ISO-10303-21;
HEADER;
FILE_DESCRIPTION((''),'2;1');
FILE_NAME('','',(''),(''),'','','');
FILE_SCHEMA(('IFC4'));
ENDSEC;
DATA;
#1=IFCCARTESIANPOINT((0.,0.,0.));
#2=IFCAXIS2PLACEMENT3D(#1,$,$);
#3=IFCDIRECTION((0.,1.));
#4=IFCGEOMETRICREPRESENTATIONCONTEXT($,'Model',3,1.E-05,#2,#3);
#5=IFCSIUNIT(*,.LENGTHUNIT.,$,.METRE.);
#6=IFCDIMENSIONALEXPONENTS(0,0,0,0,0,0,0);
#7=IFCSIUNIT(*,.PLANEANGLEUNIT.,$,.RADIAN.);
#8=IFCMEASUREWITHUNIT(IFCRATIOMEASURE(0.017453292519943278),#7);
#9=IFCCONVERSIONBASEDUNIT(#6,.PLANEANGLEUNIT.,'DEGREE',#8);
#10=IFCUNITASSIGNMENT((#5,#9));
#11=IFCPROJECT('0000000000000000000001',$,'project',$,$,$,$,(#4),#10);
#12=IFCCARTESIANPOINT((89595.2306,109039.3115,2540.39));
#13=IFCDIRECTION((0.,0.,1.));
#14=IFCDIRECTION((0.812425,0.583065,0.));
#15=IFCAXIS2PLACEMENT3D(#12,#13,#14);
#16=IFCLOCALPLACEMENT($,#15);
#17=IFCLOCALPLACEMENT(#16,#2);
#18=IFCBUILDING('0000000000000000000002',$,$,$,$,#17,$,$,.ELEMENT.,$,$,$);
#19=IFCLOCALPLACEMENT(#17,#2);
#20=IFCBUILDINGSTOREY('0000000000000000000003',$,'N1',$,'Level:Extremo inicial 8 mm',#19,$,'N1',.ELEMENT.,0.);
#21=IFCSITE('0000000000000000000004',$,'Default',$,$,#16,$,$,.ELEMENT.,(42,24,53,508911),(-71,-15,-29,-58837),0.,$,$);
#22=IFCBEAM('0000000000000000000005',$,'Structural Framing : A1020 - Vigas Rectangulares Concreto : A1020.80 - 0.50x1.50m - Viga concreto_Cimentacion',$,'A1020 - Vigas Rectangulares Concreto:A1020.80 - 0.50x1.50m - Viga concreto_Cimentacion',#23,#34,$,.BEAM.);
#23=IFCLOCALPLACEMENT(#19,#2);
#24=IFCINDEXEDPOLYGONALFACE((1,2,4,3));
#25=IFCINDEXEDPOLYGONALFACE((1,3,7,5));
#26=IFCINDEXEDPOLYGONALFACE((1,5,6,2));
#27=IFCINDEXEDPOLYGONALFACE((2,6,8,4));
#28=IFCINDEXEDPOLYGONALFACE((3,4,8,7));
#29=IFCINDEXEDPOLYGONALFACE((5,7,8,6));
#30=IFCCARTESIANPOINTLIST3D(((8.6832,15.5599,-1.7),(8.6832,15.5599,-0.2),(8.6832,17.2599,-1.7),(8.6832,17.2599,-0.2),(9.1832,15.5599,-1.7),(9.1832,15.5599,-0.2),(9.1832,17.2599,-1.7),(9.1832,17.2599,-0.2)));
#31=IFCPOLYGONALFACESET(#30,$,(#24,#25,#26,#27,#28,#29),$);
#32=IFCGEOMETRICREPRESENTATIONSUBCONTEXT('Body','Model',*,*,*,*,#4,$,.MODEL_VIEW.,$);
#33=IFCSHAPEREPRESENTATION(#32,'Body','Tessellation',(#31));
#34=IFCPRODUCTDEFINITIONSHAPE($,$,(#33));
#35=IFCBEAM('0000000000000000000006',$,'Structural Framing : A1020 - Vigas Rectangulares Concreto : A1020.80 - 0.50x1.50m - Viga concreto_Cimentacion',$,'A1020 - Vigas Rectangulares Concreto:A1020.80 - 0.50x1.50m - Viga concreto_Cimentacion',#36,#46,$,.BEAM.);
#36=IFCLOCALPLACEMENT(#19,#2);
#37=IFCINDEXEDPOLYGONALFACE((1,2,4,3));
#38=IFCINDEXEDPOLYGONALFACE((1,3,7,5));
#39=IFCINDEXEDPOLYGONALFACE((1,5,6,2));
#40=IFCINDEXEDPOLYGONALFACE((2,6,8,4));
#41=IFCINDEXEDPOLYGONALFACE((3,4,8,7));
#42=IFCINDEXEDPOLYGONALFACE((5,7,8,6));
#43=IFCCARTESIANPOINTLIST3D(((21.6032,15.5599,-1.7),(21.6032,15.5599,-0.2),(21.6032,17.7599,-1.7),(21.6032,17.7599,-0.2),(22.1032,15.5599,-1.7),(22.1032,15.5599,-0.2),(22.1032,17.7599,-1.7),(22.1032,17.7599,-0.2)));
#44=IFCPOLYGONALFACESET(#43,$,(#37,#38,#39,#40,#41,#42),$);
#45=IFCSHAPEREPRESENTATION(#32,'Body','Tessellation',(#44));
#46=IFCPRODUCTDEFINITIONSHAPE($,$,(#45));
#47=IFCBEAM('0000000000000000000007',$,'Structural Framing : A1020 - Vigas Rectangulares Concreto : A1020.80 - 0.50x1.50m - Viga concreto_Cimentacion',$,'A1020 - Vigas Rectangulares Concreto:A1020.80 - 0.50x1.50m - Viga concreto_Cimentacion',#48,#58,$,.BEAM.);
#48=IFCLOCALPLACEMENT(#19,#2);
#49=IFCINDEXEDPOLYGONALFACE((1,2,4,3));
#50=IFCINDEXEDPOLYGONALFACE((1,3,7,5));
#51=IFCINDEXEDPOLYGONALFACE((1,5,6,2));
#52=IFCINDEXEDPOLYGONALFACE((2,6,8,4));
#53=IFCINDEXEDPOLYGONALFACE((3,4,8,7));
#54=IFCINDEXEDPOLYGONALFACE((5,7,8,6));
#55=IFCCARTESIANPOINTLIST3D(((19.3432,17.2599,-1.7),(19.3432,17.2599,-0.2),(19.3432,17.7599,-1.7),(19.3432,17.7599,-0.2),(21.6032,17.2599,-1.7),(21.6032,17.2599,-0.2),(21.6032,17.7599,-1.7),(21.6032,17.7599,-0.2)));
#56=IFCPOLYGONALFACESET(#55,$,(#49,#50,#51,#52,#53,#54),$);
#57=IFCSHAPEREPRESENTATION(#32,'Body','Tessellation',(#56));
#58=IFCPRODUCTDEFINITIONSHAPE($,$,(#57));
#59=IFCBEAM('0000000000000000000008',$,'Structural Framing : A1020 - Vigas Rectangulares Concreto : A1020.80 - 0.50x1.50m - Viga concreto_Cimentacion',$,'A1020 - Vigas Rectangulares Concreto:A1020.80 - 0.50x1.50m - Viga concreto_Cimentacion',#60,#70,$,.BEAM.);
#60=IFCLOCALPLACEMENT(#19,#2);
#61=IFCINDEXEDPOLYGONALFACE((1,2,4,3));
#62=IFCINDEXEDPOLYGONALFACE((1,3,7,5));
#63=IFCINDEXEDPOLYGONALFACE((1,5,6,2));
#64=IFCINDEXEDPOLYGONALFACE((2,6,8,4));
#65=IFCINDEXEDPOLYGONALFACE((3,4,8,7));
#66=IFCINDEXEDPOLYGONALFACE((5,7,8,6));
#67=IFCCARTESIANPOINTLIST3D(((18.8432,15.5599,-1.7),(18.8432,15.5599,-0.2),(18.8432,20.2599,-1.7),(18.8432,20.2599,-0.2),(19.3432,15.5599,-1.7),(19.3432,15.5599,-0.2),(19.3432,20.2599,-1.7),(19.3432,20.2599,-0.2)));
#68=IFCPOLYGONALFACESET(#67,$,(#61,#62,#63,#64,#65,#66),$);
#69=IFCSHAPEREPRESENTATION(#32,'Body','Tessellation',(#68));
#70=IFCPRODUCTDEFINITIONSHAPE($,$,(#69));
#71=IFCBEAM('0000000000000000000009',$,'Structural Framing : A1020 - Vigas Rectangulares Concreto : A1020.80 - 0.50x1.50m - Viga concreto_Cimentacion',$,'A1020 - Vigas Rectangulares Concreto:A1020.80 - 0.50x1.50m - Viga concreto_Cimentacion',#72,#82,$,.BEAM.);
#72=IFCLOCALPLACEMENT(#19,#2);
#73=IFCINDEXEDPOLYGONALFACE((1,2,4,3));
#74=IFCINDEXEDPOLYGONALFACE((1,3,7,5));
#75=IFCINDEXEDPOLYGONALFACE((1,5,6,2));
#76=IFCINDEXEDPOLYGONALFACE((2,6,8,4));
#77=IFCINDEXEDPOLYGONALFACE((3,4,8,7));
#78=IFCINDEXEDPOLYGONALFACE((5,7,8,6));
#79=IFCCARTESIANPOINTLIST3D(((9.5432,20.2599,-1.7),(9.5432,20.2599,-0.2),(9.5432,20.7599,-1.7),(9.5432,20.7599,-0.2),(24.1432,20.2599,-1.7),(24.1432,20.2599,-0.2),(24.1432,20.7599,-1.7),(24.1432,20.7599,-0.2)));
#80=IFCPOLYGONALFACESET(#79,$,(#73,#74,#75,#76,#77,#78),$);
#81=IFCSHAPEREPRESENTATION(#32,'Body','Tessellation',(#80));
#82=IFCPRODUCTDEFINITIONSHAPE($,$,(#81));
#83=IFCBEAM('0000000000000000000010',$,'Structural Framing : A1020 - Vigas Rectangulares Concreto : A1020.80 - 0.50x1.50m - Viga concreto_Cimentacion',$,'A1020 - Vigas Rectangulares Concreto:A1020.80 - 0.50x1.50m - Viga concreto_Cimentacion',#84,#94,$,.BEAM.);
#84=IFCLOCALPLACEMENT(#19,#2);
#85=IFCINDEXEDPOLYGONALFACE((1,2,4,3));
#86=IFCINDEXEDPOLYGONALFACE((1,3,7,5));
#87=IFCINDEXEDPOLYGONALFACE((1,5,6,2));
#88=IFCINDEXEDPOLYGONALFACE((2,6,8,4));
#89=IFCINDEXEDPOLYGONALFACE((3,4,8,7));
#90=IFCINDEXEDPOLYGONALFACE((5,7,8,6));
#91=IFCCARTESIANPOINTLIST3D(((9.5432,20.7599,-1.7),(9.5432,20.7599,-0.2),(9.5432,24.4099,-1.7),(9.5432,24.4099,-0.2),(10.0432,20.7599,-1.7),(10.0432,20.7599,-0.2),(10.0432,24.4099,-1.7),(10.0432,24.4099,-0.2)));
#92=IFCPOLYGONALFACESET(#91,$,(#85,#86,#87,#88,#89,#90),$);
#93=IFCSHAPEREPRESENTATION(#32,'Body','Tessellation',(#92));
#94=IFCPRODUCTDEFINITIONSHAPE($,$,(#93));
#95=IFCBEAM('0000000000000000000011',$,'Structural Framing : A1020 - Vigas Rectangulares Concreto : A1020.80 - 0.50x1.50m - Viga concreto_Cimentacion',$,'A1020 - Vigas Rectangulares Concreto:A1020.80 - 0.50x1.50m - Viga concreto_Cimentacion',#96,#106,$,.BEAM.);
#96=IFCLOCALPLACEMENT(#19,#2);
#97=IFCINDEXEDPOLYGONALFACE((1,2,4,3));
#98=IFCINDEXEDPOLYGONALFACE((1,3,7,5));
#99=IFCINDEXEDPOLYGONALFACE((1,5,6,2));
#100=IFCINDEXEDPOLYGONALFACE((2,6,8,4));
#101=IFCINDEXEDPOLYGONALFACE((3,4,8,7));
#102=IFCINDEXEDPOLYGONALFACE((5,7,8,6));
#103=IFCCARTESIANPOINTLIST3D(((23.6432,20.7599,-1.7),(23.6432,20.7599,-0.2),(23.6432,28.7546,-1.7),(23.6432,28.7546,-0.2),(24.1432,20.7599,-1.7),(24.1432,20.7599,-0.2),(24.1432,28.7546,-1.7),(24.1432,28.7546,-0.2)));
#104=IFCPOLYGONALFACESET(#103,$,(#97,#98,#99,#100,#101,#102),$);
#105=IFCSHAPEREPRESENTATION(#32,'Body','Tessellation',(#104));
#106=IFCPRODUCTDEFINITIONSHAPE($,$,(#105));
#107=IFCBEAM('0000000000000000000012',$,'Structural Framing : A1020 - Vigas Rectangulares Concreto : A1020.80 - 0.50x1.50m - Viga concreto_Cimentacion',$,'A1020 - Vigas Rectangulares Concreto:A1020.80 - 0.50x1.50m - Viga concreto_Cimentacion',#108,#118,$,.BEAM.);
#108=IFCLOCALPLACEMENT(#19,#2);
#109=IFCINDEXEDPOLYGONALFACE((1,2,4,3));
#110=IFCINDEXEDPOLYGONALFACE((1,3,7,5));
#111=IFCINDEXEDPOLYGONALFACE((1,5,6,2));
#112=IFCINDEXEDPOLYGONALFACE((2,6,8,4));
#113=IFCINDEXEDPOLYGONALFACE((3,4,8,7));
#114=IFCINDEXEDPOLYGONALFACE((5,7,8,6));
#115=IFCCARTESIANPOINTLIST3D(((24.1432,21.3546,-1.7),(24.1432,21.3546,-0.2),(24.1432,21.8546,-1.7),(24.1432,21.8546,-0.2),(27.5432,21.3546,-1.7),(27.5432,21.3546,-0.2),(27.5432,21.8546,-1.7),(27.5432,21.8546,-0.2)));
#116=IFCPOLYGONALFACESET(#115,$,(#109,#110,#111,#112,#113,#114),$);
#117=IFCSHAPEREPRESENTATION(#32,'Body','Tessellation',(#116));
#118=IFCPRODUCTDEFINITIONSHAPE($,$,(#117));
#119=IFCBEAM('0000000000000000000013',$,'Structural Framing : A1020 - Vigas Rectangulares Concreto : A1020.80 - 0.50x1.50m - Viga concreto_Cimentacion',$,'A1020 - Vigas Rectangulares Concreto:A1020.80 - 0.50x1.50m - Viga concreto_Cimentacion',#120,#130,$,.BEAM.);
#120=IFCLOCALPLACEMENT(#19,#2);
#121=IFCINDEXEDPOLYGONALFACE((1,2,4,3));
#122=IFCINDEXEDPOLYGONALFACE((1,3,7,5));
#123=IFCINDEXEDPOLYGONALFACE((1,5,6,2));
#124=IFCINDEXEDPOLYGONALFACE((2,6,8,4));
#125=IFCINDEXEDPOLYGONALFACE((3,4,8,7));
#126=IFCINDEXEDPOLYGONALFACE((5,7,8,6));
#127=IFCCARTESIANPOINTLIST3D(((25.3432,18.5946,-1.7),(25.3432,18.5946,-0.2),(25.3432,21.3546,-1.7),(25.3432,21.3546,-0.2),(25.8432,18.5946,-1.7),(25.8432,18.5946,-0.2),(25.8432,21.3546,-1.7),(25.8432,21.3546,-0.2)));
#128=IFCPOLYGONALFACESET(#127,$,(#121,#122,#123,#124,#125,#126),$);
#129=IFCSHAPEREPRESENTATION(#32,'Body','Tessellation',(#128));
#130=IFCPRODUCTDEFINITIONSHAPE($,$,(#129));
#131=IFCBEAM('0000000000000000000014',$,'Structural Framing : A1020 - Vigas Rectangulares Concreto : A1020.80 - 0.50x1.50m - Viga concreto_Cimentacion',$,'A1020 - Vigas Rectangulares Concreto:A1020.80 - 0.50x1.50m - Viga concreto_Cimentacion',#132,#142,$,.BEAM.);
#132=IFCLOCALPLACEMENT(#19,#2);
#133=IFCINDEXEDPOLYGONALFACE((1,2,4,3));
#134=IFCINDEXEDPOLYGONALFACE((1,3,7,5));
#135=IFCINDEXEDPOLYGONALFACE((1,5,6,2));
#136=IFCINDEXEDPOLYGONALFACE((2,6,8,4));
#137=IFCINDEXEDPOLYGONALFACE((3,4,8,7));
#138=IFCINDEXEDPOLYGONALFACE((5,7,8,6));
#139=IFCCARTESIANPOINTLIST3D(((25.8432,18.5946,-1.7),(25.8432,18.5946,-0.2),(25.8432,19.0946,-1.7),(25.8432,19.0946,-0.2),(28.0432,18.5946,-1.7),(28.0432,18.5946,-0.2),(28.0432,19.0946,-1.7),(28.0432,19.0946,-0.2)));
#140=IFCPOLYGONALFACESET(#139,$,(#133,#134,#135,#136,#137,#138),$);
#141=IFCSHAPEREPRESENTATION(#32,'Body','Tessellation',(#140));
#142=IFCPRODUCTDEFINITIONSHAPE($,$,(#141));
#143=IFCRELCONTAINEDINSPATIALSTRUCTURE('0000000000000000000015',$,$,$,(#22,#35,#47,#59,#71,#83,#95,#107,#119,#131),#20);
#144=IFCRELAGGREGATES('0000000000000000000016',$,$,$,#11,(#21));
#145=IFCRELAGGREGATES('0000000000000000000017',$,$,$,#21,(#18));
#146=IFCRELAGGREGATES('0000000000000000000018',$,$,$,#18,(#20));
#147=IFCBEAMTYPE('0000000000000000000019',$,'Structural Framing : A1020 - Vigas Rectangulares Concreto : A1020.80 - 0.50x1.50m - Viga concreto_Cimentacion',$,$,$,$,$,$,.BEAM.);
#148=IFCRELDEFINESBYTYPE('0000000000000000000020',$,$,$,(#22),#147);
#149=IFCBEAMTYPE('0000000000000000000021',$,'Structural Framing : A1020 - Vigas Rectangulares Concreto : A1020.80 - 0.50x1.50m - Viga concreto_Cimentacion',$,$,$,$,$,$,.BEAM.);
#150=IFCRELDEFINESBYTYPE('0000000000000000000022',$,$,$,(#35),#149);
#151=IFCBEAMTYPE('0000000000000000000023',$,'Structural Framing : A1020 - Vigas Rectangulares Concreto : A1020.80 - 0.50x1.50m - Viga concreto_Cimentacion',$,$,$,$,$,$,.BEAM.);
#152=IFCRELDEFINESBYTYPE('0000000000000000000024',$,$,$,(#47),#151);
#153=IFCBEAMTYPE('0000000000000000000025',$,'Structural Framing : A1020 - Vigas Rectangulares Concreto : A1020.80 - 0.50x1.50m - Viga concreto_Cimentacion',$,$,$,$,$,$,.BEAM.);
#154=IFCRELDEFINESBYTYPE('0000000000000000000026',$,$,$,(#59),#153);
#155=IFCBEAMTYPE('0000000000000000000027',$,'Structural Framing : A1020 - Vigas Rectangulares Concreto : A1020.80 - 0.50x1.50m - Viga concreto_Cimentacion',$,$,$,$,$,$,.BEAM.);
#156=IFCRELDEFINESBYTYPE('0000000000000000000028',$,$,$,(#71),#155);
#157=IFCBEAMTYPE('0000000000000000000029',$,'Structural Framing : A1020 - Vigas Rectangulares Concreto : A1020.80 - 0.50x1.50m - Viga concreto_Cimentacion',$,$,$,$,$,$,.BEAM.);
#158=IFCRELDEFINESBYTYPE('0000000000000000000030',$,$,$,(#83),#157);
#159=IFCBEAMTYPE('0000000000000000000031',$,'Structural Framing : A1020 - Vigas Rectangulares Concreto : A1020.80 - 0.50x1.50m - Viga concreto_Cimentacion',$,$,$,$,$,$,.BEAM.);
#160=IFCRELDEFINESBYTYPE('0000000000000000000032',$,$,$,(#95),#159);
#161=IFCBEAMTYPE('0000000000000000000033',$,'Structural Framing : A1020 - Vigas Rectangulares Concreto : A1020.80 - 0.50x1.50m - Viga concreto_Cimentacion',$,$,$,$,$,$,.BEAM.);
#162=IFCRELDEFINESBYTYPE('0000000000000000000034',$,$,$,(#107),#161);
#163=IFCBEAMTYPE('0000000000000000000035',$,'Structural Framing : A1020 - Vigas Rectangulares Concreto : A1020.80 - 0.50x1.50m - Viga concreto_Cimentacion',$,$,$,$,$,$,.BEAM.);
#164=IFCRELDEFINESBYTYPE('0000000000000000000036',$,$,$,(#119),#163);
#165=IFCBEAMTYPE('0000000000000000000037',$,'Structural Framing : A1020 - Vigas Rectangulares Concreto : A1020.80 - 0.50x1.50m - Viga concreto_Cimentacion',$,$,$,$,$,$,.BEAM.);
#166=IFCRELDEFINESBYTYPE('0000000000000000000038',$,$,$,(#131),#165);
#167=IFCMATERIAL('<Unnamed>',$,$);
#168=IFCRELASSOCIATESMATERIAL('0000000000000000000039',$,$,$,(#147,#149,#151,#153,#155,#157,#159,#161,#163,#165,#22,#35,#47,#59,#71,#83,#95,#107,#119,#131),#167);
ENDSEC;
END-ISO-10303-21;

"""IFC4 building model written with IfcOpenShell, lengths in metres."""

from ifc_helpers import new_model, entity, si_unit, converted_unit, direction, frame, frame_2d, origin, place, context, subcontext, project, spatial, polyline, segment, composite_curve, rectangle, outline, extrude, source, transform, mapped, material, material_profile, profile_set, profile_usage, type_object, type_shapes, element, save


model = new_model("IFC4")

# Units and contexts
model_context = context("Model", 3, precision=1e-05, world=origin(), true_north=direction((0.0, 1.0)))
body_context = subcontext(model_context, "Body", "Model", "MODEL_VIEW")
ifc_project = project(units=[si_unit("LENGTHUNIT", "METRE"), converted_unit("PLANEANGLEUNIT", "DEGREE", entity("IfcRatioMeasure", 0.017453292519943278), si_unit("PLANEANGLEUNIT", "RADIAN"), dimensions=[0, 0, 0, 0, 0, 0, 0])], contexts=[model_context])

# Site, building, storey
site_placement = place(None, frame((89595.2306, 109039.3115, 2540.39), z_axis=(0.0, 0.0, 1.0), x_axis=(0.812425, 0.583065, 0.0)))
site = spatial("IfcSite", under=ifc_project, at=site_placement, Name="Default", CompositionType="ELEMENT", RefLatitude=(42, 24, 53, 508911), RefLongitude=(-71, -15, -29, -58837), RefElevation=0.0)
building_placement = place(site_placement, origin())
building = spatial("IfcBuilding", under=site, at=building_placement, CompositionType="ELEMENT")
storey_placement = place(building_placement, origin())
storey = spatial("IfcBuildingStorey", under=building, at=storey_placement, Name="N1", ObjectType="Level:Extremo inicial 8 mm", LongName="N1", CompositionType="ELEMENT", Elevation=0.0)

# Beams
ifc_material_1 = material(Name="<Unnamed>")
ifc_material_profile_1 = material_profile(ifc_material_1, outline(composite_curve([segment(polyline([(0.25, 0.75, 0.0), (0.25, -0.75, 0.0)]), True, "CONTINUOUS"), segment(polyline([(0.25, -0.75, 0.0), (-0.25, -0.75, 0.0)]), True, "CONTINUOUS"), segment(polyline([(-0.25, -0.75, 0.0), (-0.25, 0.75, 0.0)]), True, "CONTINUOUS"), segment(polyline([(-0.25, 0.75, 0.0), (0.25, 0.75, 0.0)]), True, "CONTINUOUS")], self_intersect=False), kind="CURVE"), Name="A1020.80 - 0.50x1.50m - Viga concreto_Cimentacion")
ifc_material_profile_2 = material_profile(ifc_material_1, outline(composite_curve([segment(polyline([(-5.3373, 0.25, 0.75), (-5.3373, 0.25, -0.75)]), True, "CONTINUOUS"), segment(polyline([(-5.3373, 0.25, -0.75), (-5.3373, -0.25, -0.75)]), True, "CONTINUOUS"), segment(polyline([(-5.3373, -0.25, -0.75), (-5.3373, -0.25, 0.75)]), True, "CONTINUOUS"), segment(polyline([(-5.3373, -0.25, 0.75), (-5.3373, 0.25, 0.75)]), True, "CONTINUOUS")], self_intersect=False), kind="CURVE"), Name="A1020.80 - 0.50x1.50m - Viga concreto_Cimentacion")
ifc_profile_set_1 = profile_set([ifc_material_profile_1, ifc_material_profile_2], Name="A1020.80 - 0.50x1.50m - Viga concreto_Cimentacion")
ifc_profile_usage_1 = profile_usage(ifc_profile_set_1, cardinal=8)
beam_type_1 = type_object("IfcBeamType", Name="Structural Framing : A1020 - Vigas Rectangulares Concreto : A1020.80 - 0.50x1.50m - Viga concreto_Cimentacion", PredefinedType="BEAM", material=ifc_profile_set_1)
shared_shape_1 = source(origin(), body_context, "Body", "SweptSolid", [
    extrude(rectangle(XDim=1.5, YDim=0.5, at=frame_2d((0.0, 0.0), x_axis=(0.0, 1.0))), frame((8.9332, 17.2599, -0.95), z_axis=(0.0, -1.0, 0.0), x_axis=(-1.0, 0.0, 0.0)), (0.0, 0.0, 1.0), 1.7),
])
type_shapes(beam_type_1, [shared_shape_1])
beam_1_placement = place(storey_placement, origin())
element("IfcBeam", 1, at=beam_1_placement, inside=storey, type_object=beam_type_1, material=ifc_profile_usage_1, Name="Structural Framing : A1020 - Vigas Rectangulares Concreto : A1020.80 - 0.50x1.50m - Viga concreto_Cimentacion", ObjectType="A1020 - Vigas Rectangulares Concreto:A1020.80 - 0.50x1.50m - Viga concreto_Cimentacion", PredefinedType="BEAM", context=body_context, shape_type="MappedRepresentation", body=[
    mapped(shared_shape_1, transform((0.0, 0.0, 0.0), scale=1.0)),
])
ifc_profile_usage_2 = profile_usage(ifc_profile_set_1, cardinal=8)
beam_type_2 = type_object("IfcBeamType", Name="Structural Framing : A1020 - Vigas Rectangulares Concreto : A1020.80 - 0.50x1.50m - Viga concreto_Cimentacion", PredefinedType="BEAM", material=ifc_profile_set_1)
shared_shape_2 = source(origin(), body_context, "Body", "SweptSolid", [
    extrude(rectangle(XDim=1.5, YDim=0.5, at=frame_2d((0.0, 0.0), x_axis=(0.0, 1.0))), frame((21.8532, 15.5599, -0.95), z_axis=(0.0, 1.0, 0.0), x_axis=(-1.0, 0.0, 0.0)), (0.0, 0.0, 1.0), 2.2),
])
type_shapes(beam_type_2, [shared_shape_2])
beam_2_placement = place(storey_placement, origin())
element("IfcBeam", 2, at=beam_2_placement, inside=storey, type_object=beam_type_2, material=ifc_profile_usage_2, Name="Structural Framing : A1020 - Vigas Rectangulares Concreto : A1020.80 - 0.50x1.50m - Viga concreto_Cimentacion", ObjectType="A1020 - Vigas Rectangulares Concreto:A1020.80 - 0.50x1.50m - Viga concreto_Cimentacion", PredefinedType="BEAM", context=body_context, shape_type="MappedRepresentation", body=[
    mapped(shared_shape_2, transform((0.0, 0.0, 0.0), scale=1.0)),
])
ifc_profile_usage_3 = profile_usage(ifc_profile_set_1, cardinal=8)
beam_type_3 = type_object("IfcBeamType", Name="Structural Framing : A1020 - Vigas Rectangulares Concreto : A1020.80 - 0.50x1.50m - Viga concreto_Cimentacion", PredefinedType="BEAM", material=ifc_profile_set_1)
shared_shape_3 = source(origin(), body_context, "Body", "SweptSolid", [
    extrude(rectangle(XDim=1.5, YDim=0.5, at=frame_2d((0.0, 0.0), x_axis=(1.0, 0.0))), frame((21.6032, 17.5099, -0.95), z_axis=(-1.0, 0.0, 0.0), x_axis=(0.0, 0.0, -1.0)), (0.0, 0.0, 1.0), 2.26),
])
type_shapes(beam_type_3, [shared_shape_3])
beam_3_placement = place(storey_placement, origin())
element("IfcBeam", 3, at=beam_3_placement, inside=storey, type_object=beam_type_3, material=ifc_profile_usage_3, Name="Structural Framing : A1020 - Vigas Rectangulares Concreto : A1020.80 - 0.50x1.50m - Viga concreto_Cimentacion", ObjectType="A1020 - Vigas Rectangulares Concreto:A1020.80 - 0.50x1.50m - Viga concreto_Cimentacion", PredefinedType="BEAM", context=body_context, shape_type="MappedRepresentation", body=[
    mapped(shared_shape_3, transform((0.0, 0.0, 0.0), scale=1.0)),
])
ifc_profile_usage_4 = profile_usage(ifc_profile_set_1, cardinal=8)
beam_type_4 = type_object("IfcBeamType", Name="Structural Framing : A1020 - Vigas Rectangulares Concreto : A1020.80 - 0.50x1.50m - Viga concreto_Cimentacion", PredefinedType="BEAM", material=ifc_profile_set_1)
shared_shape_4 = source(origin(), body_context, "Body", "SweptSolid", [
    extrude(rectangle(XDim=1.5, YDim=0.5, at=frame_2d((0.0, 0.0), x_axis=(0.0, 1.0))), frame((19.0932, 15.5599, -0.95), z_axis=(0.0, 1.0, 0.0), x_axis=(-1.0, 0.0, 0.0)), (0.0, 0.0, 1.0), 4.7),
])
type_shapes(beam_type_4, [shared_shape_4])
beam_4_placement = place(storey_placement, origin())
element("IfcBeam", 4, at=beam_4_placement, inside=storey, type_object=beam_type_4, material=ifc_profile_usage_4, Name="Structural Framing : A1020 - Vigas Rectangulares Concreto : A1020.80 - 0.50x1.50m - Viga concreto_Cimentacion", ObjectType="A1020 - Vigas Rectangulares Concreto:A1020.80 - 0.50x1.50m - Viga concreto_Cimentacion", PredefinedType="BEAM", context=body_context, shape_type="MappedRepresentation", body=[
    mapped(shared_shape_4, transform((0.0, 0.0, 0.0), scale=1.0)),
])
ifc_profile_usage_5 = profile_usage(ifc_profile_set_1, cardinal=8)
beam_type_5 = type_object("IfcBeamType", Name="Structural Framing : A1020 - Vigas Rectangulares Concreto : A1020.80 - 0.50x1.50m - Viga concreto_Cimentacion", PredefinedType="BEAM", material=ifc_profile_set_1)
shared_shape_5 = source(origin(), body_context, "Body", "SweptSolid", [
    extrude(rectangle(XDim=1.5, YDim=0.5, at=frame_2d((0.0, 0.0), x_axis=(1.0, 0.0))), frame((9.5432, 20.5099, -0.95), z_axis=(1.0, 0.0, 0.0), x_axis=(0.0, 0.0, -1.0)), (0.0, 0.0, 1.0), 14.6),
])
type_shapes(beam_type_5, [shared_shape_5])
beam_5_placement = place(storey_placement, origin())
element("IfcBeam", 5, at=beam_5_placement, inside=storey, type_object=beam_type_5, material=ifc_profile_usage_5, Name="Structural Framing : A1020 - Vigas Rectangulares Concreto : A1020.80 - 0.50x1.50m - Viga concreto_Cimentacion", ObjectType="A1020 - Vigas Rectangulares Concreto:A1020.80 - 0.50x1.50m - Viga concreto_Cimentacion", PredefinedType="BEAM", context=body_context, shape_type="MappedRepresentation", body=[
    mapped(shared_shape_5, transform((0.0, 0.0, 0.0), scale=1.0)),
])
ifc_profile_usage_6 = profile_usage(ifc_profile_set_1, cardinal=8)
beam_type_6 = type_object("IfcBeamType", Name="Structural Framing : A1020 - Vigas Rectangulares Concreto : A1020.80 - 0.50x1.50m - Viga concreto_Cimentacion", PredefinedType="BEAM", material=ifc_profile_set_1)
shared_shape_6 = source(origin(), body_context, "Body", "SweptSolid", [
    extrude(rectangle(XDim=1.5, YDim=0.5, at=frame_2d((0.0, 0.0), x_axis=(0.0, 1.0))), frame((9.7932, 20.7599, -0.95), z_axis=(0.0, 1.0, 0.0), x_axis=(-1.0, 0.0, 0.0)), (0.0, 0.0, 1.0), 3.65),
])
type_shapes(beam_type_6, [shared_shape_6])
beam_6_placement = place(storey_placement, origin())
element("IfcBeam", 6, at=beam_6_placement, inside=storey, type_object=beam_type_6, material=ifc_profile_usage_6, Name="Structural Framing : A1020 - Vigas Rectangulares Concreto : A1020.80 - 0.50x1.50m - Viga concreto_Cimentacion", ObjectType="A1020 - Vigas Rectangulares Concreto:A1020.80 - 0.50x1.50m - Viga concreto_Cimentacion", PredefinedType="BEAM", context=body_context, shape_type="MappedRepresentation", body=[
    mapped(shared_shape_6, transform((0.0, 0.0, 0.0), scale=1.0)),
])
ifc_profile_usage_7 = profile_usage(ifc_profile_set_1, cardinal=8)
beam_type_7 = type_object("IfcBeamType", Name="Structural Framing : A1020 - Vigas Rectangulares Concreto : A1020.80 - 0.50x1.50m - Viga concreto_Cimentacion", PredefinedType="BEAM", material=ifc_profile_set_1)
shared_shape_7 = source(origin(), body_context, "Body", "SweptSolid", [
    extrude(rectangle(XDim=1.5, YDim=0.5, at=frame_2d((0.0, 0.0), x_axis=(0.0, 1.0))), frame((23.8932, 20.7599, -0.95), z_axis=(0.0, 1.0, 0.0), x_axis=(-1.0, 0.0, 0.0)), (0.0, 0.0, 1.0), 7.9947),
])
type_shapes(beam_type_7, [shared_shape_7])
beam_7_placement = place(storey_placement, origin())
element("IfcBeam", 7, at=beam_7_placement, inside=storey, type_object=beam_type_7, material=ifc_profile_usage_7, Name="Structural Framing : A1020 - Vigas Rectangulares Concreto : A1020.80 - 0.50x1.50m - Viga concreto_Cimentacion", ObjectType="A1020 - Vigas Rectangulares Concreto:A1020.80 - 0.50x1.50m - Viga concreto_Cimentacion", PredefinedType="BEAM", context=body_context, shape_type="MappedRepresentation", body=[
    mapped(shared_shape_7, transform((0.0, 0.0, 0.0), scale=1.0)),
])
ifc_profile_usage_8 = profile_usage(ifc_profile_set_1, cardinal=8)
beam_type_8 = type_object("IfcBeamType", Name="Structural Framing : A1020 - Vigas Rectangulares Concreto : A1020.80 - 0.50x1.50m - Viga concreto_Cimentacion", PredefinedType="BEAM", material=ifc_profile_set_1)
shared_shape_8 = source(origin(), body_context, "Body", "SweptSolid", [
    extrude(rectangle(XDim=1.5, YDim=0.5, at=frame_2d((0.0, 0.0), x_axis=(1.0, 0.0))), frame((24.1432, 21.6046, -0.95), z_axis=(1.0, 0.0, 0.0), x_axis=(0.0, 0.0, -1.0)), (0.0, 0.0, 1.0), 3.4),
])
type_shapes(beam_type_8, [shared_shape_8])
beam_8_placement = place(storey_placement, origin())
element("IfcBeam", 8, at=beam_8_placement, inside=storey, type_object=beam_type_8, material=ifc_profile_usage_8, Name="Structural Framing : A1020 - Vigas Rectangulares Concreto : A1020.80 - 0.50x1.50m - Viga concreto_Cimentacion", ObjectType="A1020 - Vigas Rectangulares Concreto:A1020.80 - 0.50x1.50m - Viga concreto_Cimentacion", PredefinedType="BEAM", context=body_context, shape_type="MappedRepresentation", body=[
    mapped(shared_shape_8, transform((0.0, 0.0, 0.0), scale=1.0)),
])
ifc_profile_usage_9 = profile_usage(ifc_profile_set_1, cardinal=8)
beam_type_9 = type_object("IfcBeamType", Name="Structural Framing : A1020 - Vigas Rectangulares Concreto : A1020.80 - 0.50x1.50m - Viga concreto_Cimentacion", PredefinedType="BEAM", material=ifc_profile_set_1)
shared_shape_9 = source(origin(), body_context, "Body", "SweptSolid", [
    extrude(rectangle(XDim=1.5, YDim=0.5, at=frame_2d((0.0, 0.0), x_axis=(0.0, 1.0))), frame((25.5932, 21.3546, -0.95), z_axis=(0.0, -1.0, 0.0), x_axis=(-1.0, 0.0, 0.0)), (0.0, 0.0, 1.0), 2.76),
])
type_shapes(beam_type_9, [shared_shape_9])
beam_9_placement = place(storey_placement, origin())
element("IfcBeam", 9, at=beam_9_placement, inside=storey, type_object=beam_type_9, material=ifc_profile_usage_9, Name="Structural Framing : A1020 - Vigas Rectangulares Concreto : A1020.80 - 0.50x1.50m - Viga concreto_Cimentacion", ObjectType="A1020 - Vigas Rectangulares Concreto:A1020.80 - 0.50x1.50m - Viga concreto_Cimentacion", PredefinedType="BEAM", context=body_context, shape_type="MappedRepresentation", body=[
    mapped(shared_shape_9, transform((0.0, 0.0, 0.0), scale=1.0)),
])
ifc_profile_usage_10 = profile_usage(ifc_profile_set_1, cardinal=8)
beam_type_10 = type_object("IfcBeamType", Name="Structural Framing : A1020 - Vigas Rectangulares Concreto : A1020.80 - 0.50x1.50m - Viga concreto_Cimentacion", PredefinedType="BEAM", material=ifc_profile_set_1)
shared_shape_10 = source(origin(), body_context, "Body", "SweptSolid", [
    extrude(rectangle(XDim=1.5, YDim=0.5, at=frame_2d((0.0, 0.0), x_axis=(1.0, 0.0))), frame((25.8432, 18.8446, -0.95), z_axis=(1.0, 0.0, 0.0), x_axis=(0.0, 0.0, -1.0)), (0.0, 0.0, 1.0), 2.2),
])
type_shapes(beam_type_10, [shared_shape_10])
beam_10_placement = place(storey_placement, origin())
element("IfcBeam", 10, at=beam_10_placement, inside=storey, type_object=beam_type_10, material=ifc_profile_usage_10, Name="Structural Framing : A1020 - Vigas Rectangulares Concreto : A1020.80 - 0.50x1.50m - Viga concreto_Cimentacion", ObjectType="A1020 - Vigas Rectangulares Concreto:A1020.80 - 0.50x1.50m - Viga concreto_Cimentacion", PredefinedType="BEAM", context=body_context, shape_type="MappedRepresentation", body=[
    mapped(shared_shape_10, transform((0.0, 0.0, 0.0), scale=1.0)),
])

save(model, "model.ifc")
